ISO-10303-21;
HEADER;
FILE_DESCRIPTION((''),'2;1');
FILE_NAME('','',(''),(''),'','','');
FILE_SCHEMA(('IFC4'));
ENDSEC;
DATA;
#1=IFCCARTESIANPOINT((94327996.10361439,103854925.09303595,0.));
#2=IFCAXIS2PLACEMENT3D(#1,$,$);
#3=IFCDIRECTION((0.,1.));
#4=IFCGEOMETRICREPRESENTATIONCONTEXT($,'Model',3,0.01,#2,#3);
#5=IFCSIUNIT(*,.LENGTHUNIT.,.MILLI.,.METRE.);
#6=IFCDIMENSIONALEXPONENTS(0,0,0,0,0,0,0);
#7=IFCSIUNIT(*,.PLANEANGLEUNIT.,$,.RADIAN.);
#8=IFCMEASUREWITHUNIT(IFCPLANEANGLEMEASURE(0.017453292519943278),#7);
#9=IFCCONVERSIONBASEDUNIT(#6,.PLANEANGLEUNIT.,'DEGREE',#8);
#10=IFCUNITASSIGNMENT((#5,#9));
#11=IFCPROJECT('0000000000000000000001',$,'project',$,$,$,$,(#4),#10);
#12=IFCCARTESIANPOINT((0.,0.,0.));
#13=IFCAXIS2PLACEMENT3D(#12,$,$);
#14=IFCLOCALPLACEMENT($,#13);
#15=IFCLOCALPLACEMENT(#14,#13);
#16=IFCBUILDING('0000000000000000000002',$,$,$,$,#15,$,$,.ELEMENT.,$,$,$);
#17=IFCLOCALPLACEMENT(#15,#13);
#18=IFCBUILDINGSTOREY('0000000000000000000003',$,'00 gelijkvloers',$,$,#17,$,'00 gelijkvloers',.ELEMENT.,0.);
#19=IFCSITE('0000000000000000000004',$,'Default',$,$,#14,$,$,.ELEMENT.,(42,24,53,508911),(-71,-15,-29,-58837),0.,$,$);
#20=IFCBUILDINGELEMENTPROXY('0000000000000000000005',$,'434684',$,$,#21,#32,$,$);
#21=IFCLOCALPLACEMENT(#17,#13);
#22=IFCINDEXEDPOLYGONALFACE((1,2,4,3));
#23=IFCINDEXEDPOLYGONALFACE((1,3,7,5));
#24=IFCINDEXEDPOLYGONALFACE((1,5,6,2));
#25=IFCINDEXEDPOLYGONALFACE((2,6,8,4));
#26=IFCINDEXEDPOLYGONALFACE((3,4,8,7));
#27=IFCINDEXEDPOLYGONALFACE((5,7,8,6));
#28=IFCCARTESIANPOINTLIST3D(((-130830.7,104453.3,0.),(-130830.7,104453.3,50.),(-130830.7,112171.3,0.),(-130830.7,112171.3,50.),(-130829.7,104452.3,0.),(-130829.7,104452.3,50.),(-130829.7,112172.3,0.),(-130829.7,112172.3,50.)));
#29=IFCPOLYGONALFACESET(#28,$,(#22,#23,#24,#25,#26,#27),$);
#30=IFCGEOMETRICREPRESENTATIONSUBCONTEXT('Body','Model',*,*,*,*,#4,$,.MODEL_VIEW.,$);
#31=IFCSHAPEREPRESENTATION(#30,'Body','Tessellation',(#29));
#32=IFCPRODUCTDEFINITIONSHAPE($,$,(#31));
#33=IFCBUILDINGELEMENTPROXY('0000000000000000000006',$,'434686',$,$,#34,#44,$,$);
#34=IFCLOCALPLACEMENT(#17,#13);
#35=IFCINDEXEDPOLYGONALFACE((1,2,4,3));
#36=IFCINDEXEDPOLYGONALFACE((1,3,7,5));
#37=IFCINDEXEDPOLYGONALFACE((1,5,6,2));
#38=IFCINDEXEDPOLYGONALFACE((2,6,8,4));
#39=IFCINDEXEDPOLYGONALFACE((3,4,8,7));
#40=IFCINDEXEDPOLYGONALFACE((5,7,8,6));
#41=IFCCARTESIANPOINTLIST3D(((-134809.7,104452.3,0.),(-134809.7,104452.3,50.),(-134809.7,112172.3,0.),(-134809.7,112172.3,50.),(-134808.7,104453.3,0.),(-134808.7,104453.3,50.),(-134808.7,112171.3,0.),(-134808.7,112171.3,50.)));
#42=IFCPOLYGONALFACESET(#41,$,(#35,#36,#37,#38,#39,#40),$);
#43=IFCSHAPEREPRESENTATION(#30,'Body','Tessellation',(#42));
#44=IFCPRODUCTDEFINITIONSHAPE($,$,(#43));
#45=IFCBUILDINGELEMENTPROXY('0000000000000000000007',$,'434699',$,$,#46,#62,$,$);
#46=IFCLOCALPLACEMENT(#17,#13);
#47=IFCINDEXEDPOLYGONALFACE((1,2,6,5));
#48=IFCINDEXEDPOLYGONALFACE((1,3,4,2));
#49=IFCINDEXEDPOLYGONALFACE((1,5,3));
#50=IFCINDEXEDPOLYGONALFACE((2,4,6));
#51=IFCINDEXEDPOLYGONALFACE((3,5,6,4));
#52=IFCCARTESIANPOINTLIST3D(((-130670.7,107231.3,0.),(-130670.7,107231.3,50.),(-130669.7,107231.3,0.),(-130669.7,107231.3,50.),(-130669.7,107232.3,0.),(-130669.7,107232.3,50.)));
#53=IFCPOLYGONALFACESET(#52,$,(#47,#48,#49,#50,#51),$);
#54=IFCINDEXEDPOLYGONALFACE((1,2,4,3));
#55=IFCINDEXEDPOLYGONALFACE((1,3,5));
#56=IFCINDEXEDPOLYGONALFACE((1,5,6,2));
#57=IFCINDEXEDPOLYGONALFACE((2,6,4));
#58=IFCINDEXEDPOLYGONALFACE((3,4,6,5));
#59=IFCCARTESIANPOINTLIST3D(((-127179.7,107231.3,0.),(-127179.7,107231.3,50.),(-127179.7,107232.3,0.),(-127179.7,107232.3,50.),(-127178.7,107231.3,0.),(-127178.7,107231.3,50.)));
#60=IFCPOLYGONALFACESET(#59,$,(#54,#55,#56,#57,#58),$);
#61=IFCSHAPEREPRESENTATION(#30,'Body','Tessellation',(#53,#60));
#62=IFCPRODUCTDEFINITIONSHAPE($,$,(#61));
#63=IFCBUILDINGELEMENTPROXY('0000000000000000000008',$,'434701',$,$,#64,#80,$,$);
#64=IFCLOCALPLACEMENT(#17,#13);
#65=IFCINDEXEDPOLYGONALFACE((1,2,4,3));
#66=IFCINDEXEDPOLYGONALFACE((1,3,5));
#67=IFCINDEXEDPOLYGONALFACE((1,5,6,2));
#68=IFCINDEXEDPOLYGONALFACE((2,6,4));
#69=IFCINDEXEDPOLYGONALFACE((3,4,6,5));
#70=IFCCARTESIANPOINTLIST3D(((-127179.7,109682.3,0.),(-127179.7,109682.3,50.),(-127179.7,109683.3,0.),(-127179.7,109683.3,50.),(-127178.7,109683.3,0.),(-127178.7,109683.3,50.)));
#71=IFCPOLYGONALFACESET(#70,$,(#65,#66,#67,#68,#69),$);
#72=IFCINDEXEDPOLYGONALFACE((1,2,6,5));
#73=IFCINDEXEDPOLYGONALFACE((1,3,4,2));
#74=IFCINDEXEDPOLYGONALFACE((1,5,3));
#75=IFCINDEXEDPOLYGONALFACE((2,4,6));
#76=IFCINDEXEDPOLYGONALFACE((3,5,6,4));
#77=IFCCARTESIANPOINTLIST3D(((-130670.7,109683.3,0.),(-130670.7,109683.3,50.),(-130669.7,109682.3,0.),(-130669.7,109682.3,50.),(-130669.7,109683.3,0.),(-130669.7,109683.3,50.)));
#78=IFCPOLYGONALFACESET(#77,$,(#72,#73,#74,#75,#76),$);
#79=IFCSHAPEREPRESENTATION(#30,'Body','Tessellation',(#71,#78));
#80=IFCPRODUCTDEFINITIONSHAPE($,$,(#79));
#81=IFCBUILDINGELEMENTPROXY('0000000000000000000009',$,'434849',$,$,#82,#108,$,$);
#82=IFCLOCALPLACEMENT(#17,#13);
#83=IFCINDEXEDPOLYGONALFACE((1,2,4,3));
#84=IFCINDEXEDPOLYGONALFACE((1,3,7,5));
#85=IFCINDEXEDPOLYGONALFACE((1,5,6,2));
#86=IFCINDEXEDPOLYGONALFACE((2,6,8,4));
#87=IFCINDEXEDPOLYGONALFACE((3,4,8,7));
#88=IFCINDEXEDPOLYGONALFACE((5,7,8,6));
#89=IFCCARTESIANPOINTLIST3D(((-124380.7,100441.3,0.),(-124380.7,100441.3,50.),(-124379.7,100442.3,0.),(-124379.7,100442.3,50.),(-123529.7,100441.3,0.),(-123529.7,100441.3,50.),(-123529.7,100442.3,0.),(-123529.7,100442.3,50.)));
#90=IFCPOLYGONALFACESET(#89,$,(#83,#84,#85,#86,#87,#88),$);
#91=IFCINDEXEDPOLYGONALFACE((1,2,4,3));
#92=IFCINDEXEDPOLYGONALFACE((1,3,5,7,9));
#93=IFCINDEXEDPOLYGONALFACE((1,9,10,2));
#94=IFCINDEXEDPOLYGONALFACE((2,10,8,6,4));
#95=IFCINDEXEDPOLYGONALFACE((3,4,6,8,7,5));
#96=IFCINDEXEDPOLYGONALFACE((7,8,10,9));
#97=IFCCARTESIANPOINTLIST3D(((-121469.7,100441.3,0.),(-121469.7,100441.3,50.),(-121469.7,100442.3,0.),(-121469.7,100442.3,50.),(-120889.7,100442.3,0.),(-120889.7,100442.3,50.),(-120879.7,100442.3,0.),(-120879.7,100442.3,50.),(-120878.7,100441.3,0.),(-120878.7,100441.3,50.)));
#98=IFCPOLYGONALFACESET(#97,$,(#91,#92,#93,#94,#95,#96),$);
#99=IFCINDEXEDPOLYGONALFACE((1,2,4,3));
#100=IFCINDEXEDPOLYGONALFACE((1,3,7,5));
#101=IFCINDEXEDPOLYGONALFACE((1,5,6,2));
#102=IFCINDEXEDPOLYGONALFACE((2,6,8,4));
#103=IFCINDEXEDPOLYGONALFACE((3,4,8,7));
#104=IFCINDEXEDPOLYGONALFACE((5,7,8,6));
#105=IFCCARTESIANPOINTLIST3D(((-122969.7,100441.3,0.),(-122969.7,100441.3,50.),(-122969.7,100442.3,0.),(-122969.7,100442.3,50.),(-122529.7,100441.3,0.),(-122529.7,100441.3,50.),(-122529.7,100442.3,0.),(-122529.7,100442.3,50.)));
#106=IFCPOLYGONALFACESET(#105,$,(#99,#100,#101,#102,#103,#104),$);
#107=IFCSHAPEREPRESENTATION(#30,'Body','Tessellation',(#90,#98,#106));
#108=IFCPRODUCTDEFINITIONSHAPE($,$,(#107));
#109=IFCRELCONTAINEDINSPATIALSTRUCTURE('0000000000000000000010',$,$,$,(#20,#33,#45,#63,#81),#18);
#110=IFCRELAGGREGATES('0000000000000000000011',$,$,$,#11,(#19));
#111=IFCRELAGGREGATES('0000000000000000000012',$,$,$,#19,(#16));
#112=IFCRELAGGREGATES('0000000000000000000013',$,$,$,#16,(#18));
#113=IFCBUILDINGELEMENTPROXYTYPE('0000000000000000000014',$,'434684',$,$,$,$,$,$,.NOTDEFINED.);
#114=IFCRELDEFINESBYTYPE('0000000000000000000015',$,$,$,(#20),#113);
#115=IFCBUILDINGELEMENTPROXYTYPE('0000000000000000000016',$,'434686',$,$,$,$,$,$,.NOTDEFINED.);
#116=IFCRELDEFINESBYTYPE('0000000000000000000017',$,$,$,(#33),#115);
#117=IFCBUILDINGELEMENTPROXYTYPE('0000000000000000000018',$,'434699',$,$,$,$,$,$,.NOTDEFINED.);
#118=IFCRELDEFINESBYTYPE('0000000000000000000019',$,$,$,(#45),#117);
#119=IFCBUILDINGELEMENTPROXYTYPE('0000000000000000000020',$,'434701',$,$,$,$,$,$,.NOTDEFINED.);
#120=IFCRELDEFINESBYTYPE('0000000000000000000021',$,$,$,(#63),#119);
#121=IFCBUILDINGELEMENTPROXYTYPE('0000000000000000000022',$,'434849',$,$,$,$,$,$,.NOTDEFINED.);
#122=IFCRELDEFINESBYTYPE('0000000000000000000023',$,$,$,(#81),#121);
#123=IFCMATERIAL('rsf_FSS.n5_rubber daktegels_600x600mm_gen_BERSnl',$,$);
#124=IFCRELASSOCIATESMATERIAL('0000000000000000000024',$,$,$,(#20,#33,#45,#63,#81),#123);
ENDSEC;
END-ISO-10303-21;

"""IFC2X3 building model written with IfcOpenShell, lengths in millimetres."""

from ifc_helpers import new_model, entity, si_unit, converted_unit, direction, frame, frame_2d, origin, place, context, subcontext, project, spatial, polyline, rectangle, outline, extrude, material, type_object, element, save


model = new_model("IFC2X3")

# Units and contexts
model_context = context("Model", 3, precision=0.01, world=frame((94327996.10361439, 103854925.09303595, 0.0)), true_north=direction((0.0, 1.0)))
body_context = subcontext(model_context, "Body", "Model", "MODEL_VIEW")
ifc_project = project(units=[si_unit("LENGTHUNIT", "METRE", prefix="MILLI"), converted_unit("PLANEANGLEUNIT", "DEGREE", entity("IfcPlaneAngleMeasure", 0.017453292519943278), si_unit("PLANEANGLEUNIT", "RADIAN"), dimensions=[0, 0, 0, 0, 0, 0, 0])], contexts=[model_context])

# Site, building, storey
site_placement = place(None, origin())
site = spatial("IfcSite", under=ifc_project, at=site_placement, Name="Default", CompositionType="ELEMENT", RefLatitude=(42, 24, 53, 508911), RefLongitude=(-71, -15, -29, -58837), RefElevation=0.0)
building_placement = place(site_placement, origin())
building = spatial("IfcBuilding", under=site, at=building_placement, CompositionType="ELEMENT")
storey_placement = place(building_placement, origin())
storey = spatial("IfcBuildingStorey", under=building, at=storey_placement, Name="00 gelijkvloers", LongName="00 gelijkvloers", CompositionType="ELEMENT", Elevation=0.0)

# Building element proxies
ifc_material = material(Name="rsf_FSS.n5_rubber daktegels_600x600mm_gen_BERSnl")
building_element_proxy_type_1 = type_object("IfcBuildingElementProxyType", Name="434684", PredefinedType="NOTDEFINED")
proxy_1_placement = place(storey_placement, origin())
element("IfcBuildingElementProxy", 1, at=proxy_1_placement, inside=storey, type_object=building_element_proxy_type_1, material=ifc_material, Name="434684", context=body_context, shape_type="SweptSolid", body=[
    extrude(outline(polyline([(-3859.0, -0.5), (3859.0, -0.5), (3860.0, 0.5), (-3860.0, 0.5), (-3859.0, -0.5)])), frame((-130830.2, 108312.3, 0.0), z_axis=(0.0, 0.0, 1.0), x_axis=(0.0, -1.0, 0.0)), (0.0, 0.0, 1.0), 50.0),
])
building_element_proxy_type_2 = type_object("IfcBuildingElementProxyType", Name="434686", PredefinedType="NOTDEFINED")
proxy_2_placement = place(storey_placement, origin())
element("IfcBuildingElementProxy", 2, at=proxy_2_placement, inside=storey, type_object=building_element_proxy_type_2, material=ifc_material, Name="434686", context=body_context, shape_type="SweptSolid", body=[
    extrude(outline(polyline([(-3859.0, -0.5), (3859.0, -0.5), (3860.0, 0.5), (-3860.0, 0.5), (-3859.0, -0.5)])), frame((-134809.2, 108312.3, 0.0), z_axis=(0.0, 0.0, 1.0), x_axis=(0.0, 1.0, 0.0)), (0.0, 0.0, 1.0), 50.0),
])
building_element_proxy_type_3 = type_object("IfcBuildingElementProxyType", Name="434699", PredefinedType="NOTDEFINED")
proxy_3_placement = place(storey_placement, origin())
element("IfcBuildingElementProxy", 3, at=proxy_3_placement, inside=storey, type_object=building_element_proxy_type_3, material=ifc_material, Name="434699", context=body_context, shape_type="SweptSolid", body=[
    extrude(outline(polyline([(-0.7, -0.3), (0.3, -0.3), (0.3, 0.7), (-0.7, -0.3)])), frame((-130670.0, 107231.7, 0.0)), (0.0, 0.0, 1.0), 50.0),
    extrude(outline(polyline([(-0.7, -0.3), (0.3, -0.3), (0.3, 0.7), (-0.7, -0.3)])), frame((-127179.4, 107231.7, 0.0), z_axis=(0.0, 0.0, 1.0), x_axis=(0.0, -1.0, 0.0)), (0.0, 0.0, 1.0), 50.0),
])
building_element_proxy_type_4 = type_object("IfcBuildingElementProxyType", Name="434701", PredefinedType="NOTDEFINED")
proxy_4_placement = place(storey_placement, origin())
element("IfcBuildingElementProxy", 4, at=proxy_4_placement, inside=storey, type_object=building_element_proxy_type_4, material=ifc_material, Name="434701", context=body_context, shape_type="SweptSolid", body=[
    extrude(outline(polyline([(0.3, 0.7), (-0.7, -0.3), (0.3, -0.3), (0.3, 0.7)])), frame((-127179.4, 109683.0, 0.0), z_axis=(0.0, 0.0, 1.0), x_axis=(-1.0, 0.0, 0.0)), (0.0, 0.0, 1.0), 50.0),
    extrude(outline(polyline([(-0.7, -0.3), (0.3, -0.3), (0.3, 0.7), (-0.7, -0.3)])), frame((-130670.0, 109683.0, 0.0), z_axis=(0.0, 0.0, 1.0), x_axis=(0.0, 1.0, 0.0)), (0.0, 0.0, 1.0), 50.0),
])
building_element_proxy_type_5 = type_object("IfcBuildingElementProxyType", Name="434849", PredefinedType="NOTDEFINED")
proxy_5_placement = place(storey_placement, origin())
element("IfcBuildingElementProxy", 5, at=proxy_5_placement, inside=storey, type_object=building_element_proxy_type_5, material=ifc_material, Name="434849", context=body_context, shape_type="SweptSolid", body=[
    extrude(outline(polyline([(-425.7, -0.5), (425.2, -0.5), (425.2, 0.5), (-424.7, 0.5), (-425.7, -0.5)])), frame((-123955.0, 100441.8, 0.0)), (0.0, 0.0, 1.0), 50.0),
    extrude(outline(polyline([(-352.2, -0.6), (238.8, -0.6), (237.8, 0.4), (227.8, 0.4), (-352.2, 0.4), (-352.2, -0.6)])), frame((-121117.5, 100441.9, 0.0)), (0.0, 0.0, 1.0), 50.0),
    extrude(rectangle(XDim=440.0, YDim=1.0, at=frame_2d((0.0, 0.0), x_axis=(1.0, 0.0))), frame((-122749.7, 100441.8, 0.0)), (0.0, 0.0, 1.0), 50.0),
])

save(model, "model.ifc")
